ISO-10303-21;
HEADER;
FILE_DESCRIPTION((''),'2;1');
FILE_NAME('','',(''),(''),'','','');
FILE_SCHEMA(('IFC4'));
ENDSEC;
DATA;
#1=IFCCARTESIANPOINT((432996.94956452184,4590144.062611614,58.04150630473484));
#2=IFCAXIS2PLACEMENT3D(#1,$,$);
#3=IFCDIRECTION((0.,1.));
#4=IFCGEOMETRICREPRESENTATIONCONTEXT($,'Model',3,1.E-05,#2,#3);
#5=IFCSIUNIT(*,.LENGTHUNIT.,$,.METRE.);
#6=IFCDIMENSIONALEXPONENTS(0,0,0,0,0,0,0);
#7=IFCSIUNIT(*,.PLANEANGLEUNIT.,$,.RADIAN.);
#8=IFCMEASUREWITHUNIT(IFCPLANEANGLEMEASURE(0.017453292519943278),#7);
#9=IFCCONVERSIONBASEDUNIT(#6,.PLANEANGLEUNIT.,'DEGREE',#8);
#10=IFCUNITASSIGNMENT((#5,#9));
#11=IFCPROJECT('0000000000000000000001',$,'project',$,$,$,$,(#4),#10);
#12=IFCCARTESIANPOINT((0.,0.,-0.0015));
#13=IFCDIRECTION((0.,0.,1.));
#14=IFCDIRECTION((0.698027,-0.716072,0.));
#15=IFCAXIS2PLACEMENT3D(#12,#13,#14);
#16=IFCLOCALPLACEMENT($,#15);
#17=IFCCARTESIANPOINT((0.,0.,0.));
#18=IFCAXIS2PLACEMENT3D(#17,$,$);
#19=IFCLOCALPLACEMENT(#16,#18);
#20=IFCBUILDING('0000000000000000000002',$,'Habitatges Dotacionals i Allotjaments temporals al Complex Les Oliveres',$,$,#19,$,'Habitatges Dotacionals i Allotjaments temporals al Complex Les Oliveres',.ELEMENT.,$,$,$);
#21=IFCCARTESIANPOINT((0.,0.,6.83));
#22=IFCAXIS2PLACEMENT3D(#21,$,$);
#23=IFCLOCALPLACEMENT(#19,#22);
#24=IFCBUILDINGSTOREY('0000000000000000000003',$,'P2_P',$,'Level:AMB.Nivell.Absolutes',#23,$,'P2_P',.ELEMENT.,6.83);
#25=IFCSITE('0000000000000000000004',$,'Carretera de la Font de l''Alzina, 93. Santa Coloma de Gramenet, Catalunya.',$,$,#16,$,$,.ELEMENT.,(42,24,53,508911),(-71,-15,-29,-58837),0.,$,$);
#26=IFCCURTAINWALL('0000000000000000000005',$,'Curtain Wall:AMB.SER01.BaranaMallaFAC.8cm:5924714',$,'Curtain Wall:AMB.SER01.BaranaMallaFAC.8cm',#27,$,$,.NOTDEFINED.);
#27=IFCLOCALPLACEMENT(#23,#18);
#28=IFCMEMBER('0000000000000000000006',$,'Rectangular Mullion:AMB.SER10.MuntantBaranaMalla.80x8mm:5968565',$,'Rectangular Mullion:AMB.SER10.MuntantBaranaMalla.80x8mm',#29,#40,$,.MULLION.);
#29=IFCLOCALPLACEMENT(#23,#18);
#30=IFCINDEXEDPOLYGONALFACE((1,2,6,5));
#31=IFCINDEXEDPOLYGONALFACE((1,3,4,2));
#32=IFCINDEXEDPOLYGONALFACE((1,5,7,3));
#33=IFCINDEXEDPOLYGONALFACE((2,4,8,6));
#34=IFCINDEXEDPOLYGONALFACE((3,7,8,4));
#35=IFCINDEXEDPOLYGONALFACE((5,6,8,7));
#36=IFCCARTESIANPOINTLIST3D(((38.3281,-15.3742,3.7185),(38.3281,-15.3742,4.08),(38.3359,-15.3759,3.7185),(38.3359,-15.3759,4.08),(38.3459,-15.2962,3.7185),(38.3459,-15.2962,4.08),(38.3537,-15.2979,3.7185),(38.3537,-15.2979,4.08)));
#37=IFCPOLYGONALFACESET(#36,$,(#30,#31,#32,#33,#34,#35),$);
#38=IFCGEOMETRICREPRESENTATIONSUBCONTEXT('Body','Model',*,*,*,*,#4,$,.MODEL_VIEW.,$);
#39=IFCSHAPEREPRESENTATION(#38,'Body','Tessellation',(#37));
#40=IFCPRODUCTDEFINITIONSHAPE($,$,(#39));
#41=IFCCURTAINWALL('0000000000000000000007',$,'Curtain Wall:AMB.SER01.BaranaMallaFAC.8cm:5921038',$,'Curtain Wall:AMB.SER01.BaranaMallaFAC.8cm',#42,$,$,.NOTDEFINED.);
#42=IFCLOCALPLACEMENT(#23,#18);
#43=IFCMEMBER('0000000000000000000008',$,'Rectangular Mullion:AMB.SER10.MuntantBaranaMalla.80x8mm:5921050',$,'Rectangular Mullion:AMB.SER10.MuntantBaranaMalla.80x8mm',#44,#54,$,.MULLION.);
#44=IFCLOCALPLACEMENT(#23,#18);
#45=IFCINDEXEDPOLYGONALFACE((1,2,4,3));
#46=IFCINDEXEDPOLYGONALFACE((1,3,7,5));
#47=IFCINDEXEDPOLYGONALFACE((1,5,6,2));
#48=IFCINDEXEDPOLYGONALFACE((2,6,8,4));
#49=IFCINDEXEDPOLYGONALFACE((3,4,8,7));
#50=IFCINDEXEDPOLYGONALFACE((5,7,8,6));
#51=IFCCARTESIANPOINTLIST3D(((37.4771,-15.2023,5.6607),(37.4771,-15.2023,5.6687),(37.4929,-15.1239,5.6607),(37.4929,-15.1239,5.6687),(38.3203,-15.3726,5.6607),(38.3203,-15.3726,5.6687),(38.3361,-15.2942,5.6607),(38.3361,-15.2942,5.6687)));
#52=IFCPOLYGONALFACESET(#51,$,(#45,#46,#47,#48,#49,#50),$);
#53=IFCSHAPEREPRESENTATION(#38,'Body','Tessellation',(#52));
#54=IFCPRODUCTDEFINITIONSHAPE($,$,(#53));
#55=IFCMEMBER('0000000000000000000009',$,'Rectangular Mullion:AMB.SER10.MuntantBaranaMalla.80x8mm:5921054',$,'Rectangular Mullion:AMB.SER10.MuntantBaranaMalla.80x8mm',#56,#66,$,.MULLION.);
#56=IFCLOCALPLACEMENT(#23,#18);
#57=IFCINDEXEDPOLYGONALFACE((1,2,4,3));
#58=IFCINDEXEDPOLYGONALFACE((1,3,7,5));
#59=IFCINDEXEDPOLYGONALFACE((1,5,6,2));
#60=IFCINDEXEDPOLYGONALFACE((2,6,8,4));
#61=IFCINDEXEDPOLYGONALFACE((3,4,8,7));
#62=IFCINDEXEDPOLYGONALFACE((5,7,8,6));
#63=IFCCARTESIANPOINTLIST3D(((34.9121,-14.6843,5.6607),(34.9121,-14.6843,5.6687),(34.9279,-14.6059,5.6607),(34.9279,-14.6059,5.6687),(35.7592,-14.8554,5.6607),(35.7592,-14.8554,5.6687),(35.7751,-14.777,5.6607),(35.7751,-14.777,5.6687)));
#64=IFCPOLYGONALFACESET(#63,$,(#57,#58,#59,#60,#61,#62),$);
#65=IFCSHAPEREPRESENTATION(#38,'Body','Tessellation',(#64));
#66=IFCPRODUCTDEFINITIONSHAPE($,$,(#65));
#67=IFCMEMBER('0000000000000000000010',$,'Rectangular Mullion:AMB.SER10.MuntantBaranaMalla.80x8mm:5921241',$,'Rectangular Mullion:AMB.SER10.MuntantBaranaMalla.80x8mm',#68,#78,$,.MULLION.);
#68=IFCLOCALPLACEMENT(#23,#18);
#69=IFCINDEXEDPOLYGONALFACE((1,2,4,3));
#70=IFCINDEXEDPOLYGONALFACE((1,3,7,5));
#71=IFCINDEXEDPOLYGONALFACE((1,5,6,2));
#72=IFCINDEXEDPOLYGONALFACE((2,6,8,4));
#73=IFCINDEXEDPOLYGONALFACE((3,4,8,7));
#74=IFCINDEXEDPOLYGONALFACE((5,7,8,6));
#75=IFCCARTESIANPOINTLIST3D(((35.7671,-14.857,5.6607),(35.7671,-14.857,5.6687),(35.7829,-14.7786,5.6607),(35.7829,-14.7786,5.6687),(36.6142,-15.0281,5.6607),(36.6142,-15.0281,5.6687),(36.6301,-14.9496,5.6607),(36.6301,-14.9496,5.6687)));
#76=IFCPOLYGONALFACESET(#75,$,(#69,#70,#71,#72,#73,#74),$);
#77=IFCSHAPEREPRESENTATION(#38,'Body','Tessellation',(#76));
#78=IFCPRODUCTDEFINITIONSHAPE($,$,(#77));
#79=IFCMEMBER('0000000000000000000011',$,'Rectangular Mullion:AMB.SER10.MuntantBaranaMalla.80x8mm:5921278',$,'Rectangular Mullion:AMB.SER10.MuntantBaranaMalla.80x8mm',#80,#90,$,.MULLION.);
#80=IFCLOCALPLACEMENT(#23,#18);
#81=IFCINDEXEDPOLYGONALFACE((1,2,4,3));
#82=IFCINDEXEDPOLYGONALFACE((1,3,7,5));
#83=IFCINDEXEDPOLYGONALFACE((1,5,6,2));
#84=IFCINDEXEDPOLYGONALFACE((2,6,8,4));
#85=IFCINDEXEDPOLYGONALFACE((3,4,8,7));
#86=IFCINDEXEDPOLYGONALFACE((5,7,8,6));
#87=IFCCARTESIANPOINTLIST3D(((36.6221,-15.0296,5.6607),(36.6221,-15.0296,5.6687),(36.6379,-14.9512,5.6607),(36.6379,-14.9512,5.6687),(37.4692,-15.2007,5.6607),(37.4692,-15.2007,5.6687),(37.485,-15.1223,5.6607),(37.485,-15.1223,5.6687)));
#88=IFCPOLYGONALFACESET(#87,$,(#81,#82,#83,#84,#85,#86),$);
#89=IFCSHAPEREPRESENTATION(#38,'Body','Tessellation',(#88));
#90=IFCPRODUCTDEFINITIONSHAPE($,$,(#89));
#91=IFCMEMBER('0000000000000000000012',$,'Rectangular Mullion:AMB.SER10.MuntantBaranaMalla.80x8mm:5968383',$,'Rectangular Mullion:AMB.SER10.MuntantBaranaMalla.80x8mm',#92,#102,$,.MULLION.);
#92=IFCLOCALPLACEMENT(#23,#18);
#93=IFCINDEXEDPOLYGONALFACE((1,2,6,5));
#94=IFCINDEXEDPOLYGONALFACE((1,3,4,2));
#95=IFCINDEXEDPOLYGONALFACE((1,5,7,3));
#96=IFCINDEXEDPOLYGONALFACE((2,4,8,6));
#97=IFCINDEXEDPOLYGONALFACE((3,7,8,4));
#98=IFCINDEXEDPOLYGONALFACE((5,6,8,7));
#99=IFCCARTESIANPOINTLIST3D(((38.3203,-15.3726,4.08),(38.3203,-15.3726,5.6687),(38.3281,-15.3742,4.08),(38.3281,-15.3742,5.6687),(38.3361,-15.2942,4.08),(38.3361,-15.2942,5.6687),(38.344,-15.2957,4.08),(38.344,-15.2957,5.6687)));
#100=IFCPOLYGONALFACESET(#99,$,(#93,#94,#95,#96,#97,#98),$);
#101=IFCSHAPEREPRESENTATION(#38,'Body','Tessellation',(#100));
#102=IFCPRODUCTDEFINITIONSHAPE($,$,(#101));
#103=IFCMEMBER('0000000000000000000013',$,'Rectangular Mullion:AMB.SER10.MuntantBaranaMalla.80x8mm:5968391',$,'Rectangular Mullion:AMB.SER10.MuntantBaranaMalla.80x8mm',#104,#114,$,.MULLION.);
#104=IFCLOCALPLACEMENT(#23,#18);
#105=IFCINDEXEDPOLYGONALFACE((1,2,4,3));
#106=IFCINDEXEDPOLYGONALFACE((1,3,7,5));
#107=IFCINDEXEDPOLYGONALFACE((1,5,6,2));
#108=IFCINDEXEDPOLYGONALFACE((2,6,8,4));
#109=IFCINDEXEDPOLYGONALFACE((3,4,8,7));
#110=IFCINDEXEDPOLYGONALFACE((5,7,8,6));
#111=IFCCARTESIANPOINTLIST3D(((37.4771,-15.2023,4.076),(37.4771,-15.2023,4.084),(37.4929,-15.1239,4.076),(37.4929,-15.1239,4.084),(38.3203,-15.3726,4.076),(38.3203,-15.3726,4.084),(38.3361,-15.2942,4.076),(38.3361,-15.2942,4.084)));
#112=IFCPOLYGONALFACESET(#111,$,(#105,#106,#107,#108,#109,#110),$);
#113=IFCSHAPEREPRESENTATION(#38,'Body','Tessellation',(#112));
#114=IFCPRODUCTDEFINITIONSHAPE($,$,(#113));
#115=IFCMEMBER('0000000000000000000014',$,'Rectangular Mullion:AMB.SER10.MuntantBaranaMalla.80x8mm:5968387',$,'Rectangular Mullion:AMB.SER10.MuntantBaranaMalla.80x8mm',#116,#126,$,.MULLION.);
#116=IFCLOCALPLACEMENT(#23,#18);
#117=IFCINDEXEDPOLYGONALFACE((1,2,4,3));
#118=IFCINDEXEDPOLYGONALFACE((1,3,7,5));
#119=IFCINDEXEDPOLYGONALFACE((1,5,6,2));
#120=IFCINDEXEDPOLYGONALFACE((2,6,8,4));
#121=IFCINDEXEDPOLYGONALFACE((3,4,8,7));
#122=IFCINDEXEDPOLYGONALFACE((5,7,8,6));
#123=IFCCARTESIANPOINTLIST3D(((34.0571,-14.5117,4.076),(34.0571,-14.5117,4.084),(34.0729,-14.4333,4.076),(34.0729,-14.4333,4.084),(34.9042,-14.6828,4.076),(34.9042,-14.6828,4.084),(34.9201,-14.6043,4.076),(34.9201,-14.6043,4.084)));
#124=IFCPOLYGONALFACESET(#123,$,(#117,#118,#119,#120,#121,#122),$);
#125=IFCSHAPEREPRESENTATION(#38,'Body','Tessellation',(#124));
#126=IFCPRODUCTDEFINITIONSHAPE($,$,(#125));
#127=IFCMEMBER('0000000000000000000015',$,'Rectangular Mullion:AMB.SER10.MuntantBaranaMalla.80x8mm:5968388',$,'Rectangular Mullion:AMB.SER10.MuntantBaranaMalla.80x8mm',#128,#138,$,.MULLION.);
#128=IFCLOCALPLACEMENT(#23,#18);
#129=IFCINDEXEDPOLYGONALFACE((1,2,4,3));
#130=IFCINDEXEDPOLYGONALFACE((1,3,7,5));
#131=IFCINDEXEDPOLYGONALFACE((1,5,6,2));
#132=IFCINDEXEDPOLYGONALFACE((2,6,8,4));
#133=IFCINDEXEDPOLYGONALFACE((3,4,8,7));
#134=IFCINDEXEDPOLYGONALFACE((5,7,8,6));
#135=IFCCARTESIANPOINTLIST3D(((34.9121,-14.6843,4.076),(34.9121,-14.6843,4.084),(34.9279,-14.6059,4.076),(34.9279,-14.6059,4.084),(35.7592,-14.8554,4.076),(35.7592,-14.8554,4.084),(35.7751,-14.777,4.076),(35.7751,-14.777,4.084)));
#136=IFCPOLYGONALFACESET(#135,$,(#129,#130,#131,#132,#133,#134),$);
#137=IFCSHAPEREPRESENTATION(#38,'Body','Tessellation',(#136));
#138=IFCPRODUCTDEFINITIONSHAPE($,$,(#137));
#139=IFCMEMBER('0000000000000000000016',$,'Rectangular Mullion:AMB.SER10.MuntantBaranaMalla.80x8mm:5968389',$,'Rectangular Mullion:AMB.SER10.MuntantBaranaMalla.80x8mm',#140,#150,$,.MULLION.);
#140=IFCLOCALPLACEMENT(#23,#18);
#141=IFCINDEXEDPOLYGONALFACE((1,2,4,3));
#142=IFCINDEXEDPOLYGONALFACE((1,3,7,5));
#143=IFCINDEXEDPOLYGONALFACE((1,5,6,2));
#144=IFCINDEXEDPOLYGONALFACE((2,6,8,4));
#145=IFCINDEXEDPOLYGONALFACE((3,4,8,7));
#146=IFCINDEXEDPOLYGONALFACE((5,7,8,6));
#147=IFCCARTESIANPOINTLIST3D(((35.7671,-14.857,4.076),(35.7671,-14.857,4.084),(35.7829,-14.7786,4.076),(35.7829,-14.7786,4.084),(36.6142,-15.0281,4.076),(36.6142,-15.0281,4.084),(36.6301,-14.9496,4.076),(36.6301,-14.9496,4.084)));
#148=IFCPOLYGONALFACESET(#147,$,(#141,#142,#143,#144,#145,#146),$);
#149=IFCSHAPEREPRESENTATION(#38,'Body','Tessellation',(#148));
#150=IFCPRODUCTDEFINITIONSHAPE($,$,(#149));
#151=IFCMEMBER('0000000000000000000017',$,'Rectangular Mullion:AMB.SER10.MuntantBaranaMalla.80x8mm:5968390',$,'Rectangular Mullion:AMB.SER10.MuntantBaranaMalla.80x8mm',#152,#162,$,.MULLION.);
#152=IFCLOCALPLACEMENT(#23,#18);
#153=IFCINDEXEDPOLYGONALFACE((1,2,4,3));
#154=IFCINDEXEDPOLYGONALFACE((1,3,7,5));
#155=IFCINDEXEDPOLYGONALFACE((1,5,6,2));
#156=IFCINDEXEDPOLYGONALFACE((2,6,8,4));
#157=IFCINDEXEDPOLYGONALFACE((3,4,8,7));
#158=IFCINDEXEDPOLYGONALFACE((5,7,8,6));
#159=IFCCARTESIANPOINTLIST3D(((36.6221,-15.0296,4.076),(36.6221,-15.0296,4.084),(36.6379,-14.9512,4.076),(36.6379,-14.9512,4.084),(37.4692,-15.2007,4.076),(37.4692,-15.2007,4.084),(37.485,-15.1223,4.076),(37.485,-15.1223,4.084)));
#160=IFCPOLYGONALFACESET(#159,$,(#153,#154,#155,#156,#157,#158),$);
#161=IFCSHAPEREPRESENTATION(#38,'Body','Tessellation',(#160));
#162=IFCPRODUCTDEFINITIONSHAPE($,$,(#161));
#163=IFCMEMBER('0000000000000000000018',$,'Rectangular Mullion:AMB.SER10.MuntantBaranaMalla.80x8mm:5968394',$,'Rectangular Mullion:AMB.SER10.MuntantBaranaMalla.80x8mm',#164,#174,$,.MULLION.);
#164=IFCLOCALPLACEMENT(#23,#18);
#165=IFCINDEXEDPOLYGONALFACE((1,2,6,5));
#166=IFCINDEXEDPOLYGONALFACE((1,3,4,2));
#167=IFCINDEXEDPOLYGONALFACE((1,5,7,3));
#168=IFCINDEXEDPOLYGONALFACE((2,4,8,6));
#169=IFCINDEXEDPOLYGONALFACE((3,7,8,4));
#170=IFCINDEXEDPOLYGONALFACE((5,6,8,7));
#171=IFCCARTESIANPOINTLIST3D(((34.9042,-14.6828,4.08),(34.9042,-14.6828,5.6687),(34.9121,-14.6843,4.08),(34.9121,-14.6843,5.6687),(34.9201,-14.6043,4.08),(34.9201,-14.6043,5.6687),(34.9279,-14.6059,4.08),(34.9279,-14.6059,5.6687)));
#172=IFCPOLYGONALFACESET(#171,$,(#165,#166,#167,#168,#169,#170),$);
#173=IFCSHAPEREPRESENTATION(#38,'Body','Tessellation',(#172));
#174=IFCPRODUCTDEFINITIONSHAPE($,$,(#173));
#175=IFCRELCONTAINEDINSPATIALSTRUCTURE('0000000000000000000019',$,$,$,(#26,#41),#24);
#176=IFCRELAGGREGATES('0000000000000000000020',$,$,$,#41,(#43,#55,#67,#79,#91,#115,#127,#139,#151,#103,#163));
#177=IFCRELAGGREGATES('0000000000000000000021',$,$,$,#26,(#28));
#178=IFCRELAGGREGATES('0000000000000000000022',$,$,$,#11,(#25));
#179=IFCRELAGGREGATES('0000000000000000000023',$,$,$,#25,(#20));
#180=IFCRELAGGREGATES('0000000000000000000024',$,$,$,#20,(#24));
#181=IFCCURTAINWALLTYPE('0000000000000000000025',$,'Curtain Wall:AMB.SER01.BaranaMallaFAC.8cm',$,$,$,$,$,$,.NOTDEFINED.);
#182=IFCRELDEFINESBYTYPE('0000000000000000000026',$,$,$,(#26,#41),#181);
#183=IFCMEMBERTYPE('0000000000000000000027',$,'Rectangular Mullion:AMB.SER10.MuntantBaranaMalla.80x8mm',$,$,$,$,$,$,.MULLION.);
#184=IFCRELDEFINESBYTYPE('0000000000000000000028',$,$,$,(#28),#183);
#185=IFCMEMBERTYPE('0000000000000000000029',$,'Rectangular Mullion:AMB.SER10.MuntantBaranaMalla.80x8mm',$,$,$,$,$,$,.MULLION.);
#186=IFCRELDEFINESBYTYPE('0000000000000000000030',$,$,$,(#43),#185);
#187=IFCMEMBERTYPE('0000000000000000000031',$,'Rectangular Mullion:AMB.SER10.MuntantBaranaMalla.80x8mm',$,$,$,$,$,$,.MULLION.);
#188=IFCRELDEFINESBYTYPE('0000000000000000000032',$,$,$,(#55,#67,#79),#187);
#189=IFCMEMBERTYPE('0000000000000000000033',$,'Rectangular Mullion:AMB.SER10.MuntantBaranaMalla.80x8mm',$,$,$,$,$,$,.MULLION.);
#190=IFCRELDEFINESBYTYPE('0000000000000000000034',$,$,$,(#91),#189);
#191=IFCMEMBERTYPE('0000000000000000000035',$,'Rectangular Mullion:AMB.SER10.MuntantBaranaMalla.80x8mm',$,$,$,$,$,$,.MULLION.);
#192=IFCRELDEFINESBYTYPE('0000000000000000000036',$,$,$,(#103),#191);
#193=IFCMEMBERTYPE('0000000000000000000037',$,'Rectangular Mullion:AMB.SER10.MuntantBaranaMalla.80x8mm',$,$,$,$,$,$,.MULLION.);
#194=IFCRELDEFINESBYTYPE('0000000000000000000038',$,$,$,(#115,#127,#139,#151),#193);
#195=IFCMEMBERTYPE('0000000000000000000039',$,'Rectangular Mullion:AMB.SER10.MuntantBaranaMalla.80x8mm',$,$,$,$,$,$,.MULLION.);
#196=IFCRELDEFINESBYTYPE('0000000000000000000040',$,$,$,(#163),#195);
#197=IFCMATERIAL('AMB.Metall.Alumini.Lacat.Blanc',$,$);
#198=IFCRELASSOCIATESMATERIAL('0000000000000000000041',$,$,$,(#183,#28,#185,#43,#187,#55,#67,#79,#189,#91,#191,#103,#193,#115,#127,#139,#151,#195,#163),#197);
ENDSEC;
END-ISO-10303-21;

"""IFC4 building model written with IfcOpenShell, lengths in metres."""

from ifc_helpers import new_model, entity, si_unit, converted_unit, direction, frame, origin, place, context, subcontext, project, spatial, indexed_curve, outline, extrude, source, transform, mapped, material, type_object, type_shapes, element, aggregate, save


model = new_model("IFC4")

# Units and contexts
model_context = context("Model", 3, precision=1e-05, world=frame((432996.94956452184, 4590144.062611614, 58.04150630473484)), true_north=direction((0.0, 1.0)))
body_context = subcontext(model_context, "Body", "Model", "MODEL_VIEW")
ifc_project = project(units=[si_unit("LENGTHUNIT", "METRE"), converted_unit("PLANEANGLEUNIT", "DEGREE", entity("IfcPlaneAngleMeasure", 0.017453292519943278), si_unit("PLANEANGLEUNIT", "RADIAN"), dimensions=[0, 0, 0, 0, 0, 0, 0])], contexts=[model_context])

# Site, building, storey
site_placement = place(None, frame((0.0, 0.0, -0.0015), z_axis=(0.0, 0.0, 1.0), x_axis=(0.698027, -0.716072, 0.0)))
site = spatial("IfcSite", under=ifc_project, at=site_placement, Name="Carretera de la Font de l'Alzina, 93. Santa Coloma de Gramenet, Catalunya.", CompositionType="ELEMENT", RefLatitude=(42, 24, 53, 508911), RefLongitude=(-71, -15, -29, -58837), RefElevation=0.0)
building_placement = place(site_placement, origin())
building = spatial("IfcBuilding", under=site, at=building_placement, Name="Habitatges Dotacionals i Allotjaments temporals al Complex Les Oliveres", LongName="Habitatges Dotacionals i Allotjaments temporals al Complex Les Oliveres", CompositionType="ELEMENT")
storey_placement = place(building_placement, frame((0.0, 0.0, 6.83)))
storey = spatial("IfcBuildingStorey", under=building, at=storey_placement, Name="P2_P", ObjectType="Level:AMB.Nivell.Absolutes", LongName="P2_P", CompositionType="ELEMENT", Elevation=6.83)

# Curtain wall, member
curtain_wall_type = type_object("IfcCurtainWallType", Name="Curtain Wall:AMB.SER01.BaranaMallaFAC.8cm", PredefinedType="NOTDEFINED")
curtain_wall_1_placement = place(storey_placement, frame((0.0, 0.0, -6.83)))
curtain_wall_1 = element("IfcCurtainWall", 1, at=curtain_wall_1_placement, inside=storey, type_object=curtain_wall_type, Name="Curtain Wall:AMB.SER01.BaranaMallaFAC.8cm:5924714", ObjectType="Curtain Wall:AMB.SER01.BaranaMallaFAC.8cm", PredefinedType="NOTDEFINED")
ifc_material_1 = material(Name="AMB.Metall.Alumini.Lacat.Blanc")
member_type_1 = type_object("IfcMemberType", Name="Rectangular Mullion:AMB.SER10.MuntantBaranaMalla.80x8mm", PredefinedType="MULLION", material=ifc_material_1)
shared_shape_1 = source(origin(), body_context, "Body", "SweptSolid", [
    extrude(outline(indexed_curve([(-0.004, -0.04), (0.004, -0.04), (0.004, 0.04), (-0.004, 0.04), (-0.004, -0.04)], self_intersect=False)), frame((-0.004, -0.04, -0.3615), z_axis=(0.0, 0.0, 1.0), x_axis=(-1.0, 0.0, 0.0)), (0.0, 0.0, 1.0), 0.3615),
])
type_shapes(member_type_1, [shared_shape_1])
member_1_placement = place(curtain_wall_1_placement, frame((38.3281, -15.3742, 10.91), z_axis=(0.0, 0.0, 1.0), x_axis=(-0.975001, 0.2222, 0.0)))
member_1 = element("IfcMember", 2, at=member_1_placement, type_object=member_type_1, material=ifc_material_1, Name="Rectangular Mullion:AMB.SER10.MuntantBaranaMalla.80x8mm:5968565", ObjectType="Rectangular Mullion:AMB.SER10.MuntantBaranaMalla.80x8mm", PredefinedType="MULLION", context=body_context, shape_type="MappedRepresentation", body=[
    mapped(shared_shape_1, transform((0.0, 0.0, 0.0), scale=1.0)),
])

# Curtain wall, members
curtain_wall_2_placement = place(storey_placement, frame((0.0, 0.0, -6.83)))
curtain_wall_2 = element("IfcCurtainWall", 3, at=curtain_wall_2_placement, inside=storey, type_object=curtain_wall_type, Name="Curtain Wall:AMB.SER01.BaranaMallaFAC.8cm:5921038", ObjectType="Curtain Wall:AMB.SER01.BaranaMallaFAC.8cm", PredefinedType="NOTDEFINED")
member_type_2 = type_object("IfcMemberType", Name="Rectangular Mullion:AMB.SER10.MuntantBaranaMalla.80x8mm", PredefinedType="MULLION", material=ifc_material_1)
shared_shape_2 = source(origin(), body_context, "Body", "SweptSolid", [
    extrude(outline(indexed_curve([(-0.004, -0.04), (0.004, -0.04), (0.004, 0.04), (-0.004, 0.04), (-0.004, -0.04)], self_intersect=False)), frame((-0.004, -0.04, -0.8602), z_axis=(0.0, 0.0, 1.0), x_axis=(-1.0, 0.0, 0.0)), (0.0, 0.0, 1.0), 0.8602),
])
type_shapes(member_type_2, [shared_shape_2])
member_2_placement = place(curtain_wall_2_placement, frame((38.3203, -15.3726, 12.4987), z_axis=(0.980214, -0.197941, 0.0), x_axis=(0.0, 0.0, 1.0)))
member_2 = element("IfcMember", 4, at=member_2_placement, type_object=member_type_2, material=ifc_material_1, Name="Rectangular Mullion:AMB.SER10.MuntantBaranaMalla.80x8mm:5921050", ObjectType="Rectangular Mullion:AMB.SER10.MuntantBaranaMalla.80x8mm", PredefinedType="MULLION", context=body_context, shape_type="MappedRepresentation", body=[
    mapped(shared_shape_2, transform((0.0, 0.0, 0.0), scale=1.0)),
])
member_type_3 = type_object("IfcMemberType", Name="Rectangular Mullion:AMB.SER10.MuntantBaranaMalla.80x8mm", PredefinedType="MULLION", material=ifc_material_1)
shared_shape_3 = source(origin(), body_context, "Body", "SweptSolid", [
    extrude(outline(indexed_curve([(-0.004, -0.04), (0.004, -0.04), (0.004, 0.04), (-0.004, 0.04), (-0.004, -0.04)], self_intersect=False)), frame((-0.004, -0.04, -0.8642), z_axis=(0.0, 0.0, 1.0), x_axis=(-1.0, 0.0, 0.0)), (0.0, 0.0, 1.0), 0.8642),
])
type_shapes(member_type_3, [shared_shape_3])
member_3_placement = place(curtain_wall_2_placement, frame((35.7592, -14.8554, 12.4987), z_axis=(0.980214, -0.197941, 0.0), x_axis=(0.0, 0.0, 1.0)))
member_3 = element("IfcMember", 5, at=member_3_placement, type_object=member_type_3, material=ifc_material_1, Name="Rectangular Mullion:AMB.SER10.MuntantBaranaMalla.80x8mm:5921054", ObjectType="Rectangular Mullion:AMB.SER10.MuntantBaranaMalla.80x8mm", PredefinedType="MULLION", context=body_context, shape_type="MappedRepresentation", body=[
    mapped(shared_shape_3, transform((0.0, 0.0, 0.0), scale=1.0)),
])
member_4_placement = place(curtain_wall_2_placement, frame((36.6142, -15.0281, 12.4987), z_axis=(0.980214, -0.197941, 0.0), x_axis=(0.0, 0.0, 1.0)))
member_4 = element("IfcMember", 6, at=member_4_placement, type_object=member_type_3, material=ifc_material_1, Name="Rectangular Mullion:AMB.SER10.MuntantBaranaMalla.80x8mm:5921241", ObjectType="Rectangular Mullion:AMB.SER10.MuntantBaranaMalla.80x8mm", PredefinedType="MULLION", context=body_context, shape_type="MappedRepresentation", body=[
    mapped(shared_shape_3, transform((0.0, 0.0, 0.0), scale=1.0)),
])
member_5_placement = place(curtain_wall_2_placement, frame((37.4692, -15.2007, 12.4987), z_axis=(0.980214, -0.197941, 0.0), x_axis=(0.0, 0.0, 1.0)))
member_5 = element("IfcMember", 7, at=member_5_placement, type_object=member_type_3, material=ifc_material_1, Name="Rectangular Mullion:AMB.SER10.MuntantBaranaMalla.80x8mm:5921278", ObjectType="Rectangular Mullion:AMB.SER10.MuntantBaranaMalla.80x8mm", PredefinedType="MULLION", context=body_context, shape_type="MappedRepresentation", body=[
    mapped(shared_shape_3, transform((0.0, 0.0, 0.0), scale=1.0)),
])
member_type_4 = type_object("IfcMemberType", Name="Rectangular Mullion:AMB.SER10.MuntantBaranaMalla.80x8mm", PredefinedType="MULLION", material=ifc_material_1)
shared_shape_4 = source(origin(), body_context, "Body", "SweptSolid", [
    extrude(outline(indexed_curve([(-0.004, -0.04), (0.004, -0.04), (0.004, 0.04), (-0.004, 0.04), (-0.004, -0.04)], self_intersect=False)), frame((-0.004, -0.04, -1.5887), z_axis=(0.0, 0.0, 1.0), x_axis=(-1.0, 0.0, 0.0)), (0.0, 0.0, 1.0), 1.5887),
])
type_shapes(member_type_4, [shared_shape_4])
member_6_placement = place(curtain_wall_2_placement, frame((38.3281, -15.3742, 10.91), z_axis=(0.0, 0.0, -1.0), x_axis=(0.980214, -0.197941, 0.0)))
member_6 = element("IfcMember", 8, at=member_6_placement, type_object=member_type_4, material=ifc_material_1, Name="Rectangular Mullion:AMB.SER10.MuntantBaranaMalla.80x8mm:5968383", ObjectType="Rectangular Mullion:AMB.SER10.MuntantBaranaMalla.80x8mm", PredefinedType="MULLION", context=body_context, shape_type="MappedRepresentation", body=[
    mapped(shared_shape_4, transform((0.0, 0.0, 0.0), scale=1.0)),
])
member_type_5 = type_object("IfcMemberType", Name="Rectangular Mullion:AMB.SER10.MuntantBaranaMalla.80x8mm", PredefinedType="MULLION", material=ifc_material_1)
shared_shape_5 = source(origin(), body_context, "Body", "SweptSolid", [
    extrude(outline(indexed_curve([(-0.004, -0.04), (0.004, -0.04), (0.004, 0.04), (-0.004, 0.04), (-0.004, -0.04)], self_intersect=False)), frame((0.0, -0.04, -0.8602), z_axis=(0.0, 0.0, 1.0), x_axis=(-1.0, 0.0, 0.0)), (0.0, 0.0, 1.0), 0.8602),
])
type_shapes(member_type_5, [shared_shape_5])
member_7_placement = place(curtain_wall_2_placement, frame((38.3203, -15.3726, 10.91), z_axis=(0.980214, -0.197941, 0.0), x_axis=(0.0, 0.0, 1.0)))
member_7 = element("IfcMember", 9, at=member_7_placement, type_object=member_type_5, material=ifc_material_1, Name="Rectangular Mullion:AMB.SER10.MuntantBaranaMalla.80x8mm:5968391", ObjectType="Rectangular Mullion:AMB.SER10.MuntantBaranaMalla.80x8mm", PredefinedType="MULLION", context=body_context, shape_type="MappedRepresentation", body=[
    mapped(shared_shape_5, transform((0.0, 0.0, 0.0), scale=1.0)),
])
member_type_6 = type_object("IfcMemberType", Name="Rectangular Mullion:AMB.SER10.MuntantBaranaMalla.80x8mm", PredefinedType="MULLION", material=ifc_material_1)
shared_shape_6 = source(origin(), body_context, "Body", "SweptSolid", [
    extrude(outline(indexed_curve([(-0.004, -0.04), (0.004, -0.04), (0.004, 0.04), (-0.004, 0.04), (-0.004, -0.04)], self_intersect=False)), frame((0.0, -0.04, -0.8642), z_axis=(0.0, 0.0, 1.0), x_axis=(-1.0, 0.0, 0.0)), (0.0, 0.0, 1.0), 0.8642),
])
type_shapes(member_type_6, [shared_shape_6])
member_8_placement = place(curtain_wall_2_placement, frame((34.9042, -14.6828, 10.91), z_axis=(0.980214, -0.197941, 0.0), x_axis=(0.0, 0.0, 1.0)))
member_8 = element("IfcMember", 10, at=member_8_placement, type_object=member_type_6, material=ifc_material_1, Name="Rectangular Mullion:AMB.SER10.MuntantBaranaMalla.80x8mm:5968387", ObjectType="Rectangular Mullion:AMB.SER10.MuntantBaranaMalla.80x8mm", PredefinedType="MULLION", context=body_context, shape_type="MappedRepresentation", body=[
    mapped(shared_shape_6, transform((0.0, 0.0, 0.0), scale=1.0)),
])
member_9_placement = place(curtain_wall_2_placement, frame((35.7592, -14.8554, 10.91), z_axis=(0.980214, -0.197941, 0.0), x_axis=(0.0, 0.0, 1.0)))
member_9 = element("IfcMember", 11, at=member_9_placement, type_object=member_type_6, material=ifc_material_1, Name="Rectangular Mullion:AMB.SER10.MuntantBaranaMalla.80x8mm:5968388", ObjectType="Rectangular Mullion:AMB.SER10.MuntantBaranaMalla.80x8mm", PredefinedType="MULLION", context=body_context, shape_type="MappedRepresentation", body=[
    mapped(shared_shape_6, transform((0.0, 0.0, 0.0), scale=1.0)),
])
member_10_placement = place(curtain_wall_2_placement, frame((36.6142, -15.0281, 10.91), z_axis=(0.980214, -0.197941, 0.0), x_axis=(0.0, 0.0, 1.0)))
member_10 = element("IfcMember", 12, at=member_10_placement, type_object=member_type_6, material=ifc_material_1, Name="Rectangular Mullion:AMB.SER10.MuntantBaranaMalla.80x8mm:5968389", ObjectType="Rectangular Mullion:AMB.SER10.MuntantBaranaMalla.80x8mm", PredefinedType="MULLION", context=body_context, shape_type="MappedRepresentation", body=[
    mapped(shared_shape_6, transform((0.0, 0.0, 0.0), scale=1.0)),
])
member_11_placement = place(curtain_wall_2_placement, frame((37.4692, -15.2007, 10.91), z_axis=(0.980214, -0.197941, 0.0), x_axis=(0.0, 0.0, 1.0)))
member_11 = element("IfcMember", 13, at=member_11_placement, type_object=member_type_6, material=ifc_material_1, Name="Rectangular Mullion:AMB.SER10.MuntantBaranaMalla.80x8mm:5968390", ObjectType="Rectangular Mullion:AMB.SER10.MuntantBaranaMalla.80x8mm", PredefinedType="MULLION", context=body_context, shape_type="MappedRepresentation", body=[
    mapped(shared_shape_6, transform((0.0, 0.0, 0.0), scale=1.0)),
])
member_type_7 = type_object("IfcMemberType", Name="Rectangular Mullion:AMB.SER10.MuntantBaranaMalla.80x8mm", PredefinedType="MULLION", material=ifc_material_1)
shared_shape_7 = source(origin(), body_context, "Body", "SweptSolid", [
    extrude(outline(indexed_curve([(-0.004, -0.04), (0.004, -0.04), (0.004, 0.04), (-0.004, 0.04), (-0.004, -0.04)], self_intersect=False)), frame((0.0, -0.04, -1.5887), z_axis=(0.0, 0.0, 1.0), x_axis=(-1.0, 0.0, 0.0)), (0.0, 0.0, 1.0), 1.5887),
])
type_shapes(member_type_7, [shared_shape_7])
member_12_placement = place(curtain_wall_2_placement, frame((34.9082, -14.6835, 10.91), z_axis=(0.0, 0.0, -1.0), x_axis=(0.980214, -0.197941, 0.0)))
member_12 = element("IfcMember", 14, at=member_12_placement, type_object=member_type_7, material=ifc_material_1, Name="Rectangular Mullion:AMB.SER10.MuntantBaranaMalla.80x8mm:5968394", ObjectType="Rectangular Mullion:AMB.SER10.MuntantBaranaMalla.80x8mm", PredefinedType="MULLION", context=body_context, shape_type="MappedRepresentation", body=[
    mapped(shared_shape_7, transform((0.0, 0.0, 0.0), scale=1.0)),
])

aggregate(curtain_wall_2, [member_2, member_3, member_4, member_5, member_6, member_8, member_9, member_10, member_11, member_7, member_12])
aggregate(curtain_wall_1, [member_1])

save(model, "model.ifc")
